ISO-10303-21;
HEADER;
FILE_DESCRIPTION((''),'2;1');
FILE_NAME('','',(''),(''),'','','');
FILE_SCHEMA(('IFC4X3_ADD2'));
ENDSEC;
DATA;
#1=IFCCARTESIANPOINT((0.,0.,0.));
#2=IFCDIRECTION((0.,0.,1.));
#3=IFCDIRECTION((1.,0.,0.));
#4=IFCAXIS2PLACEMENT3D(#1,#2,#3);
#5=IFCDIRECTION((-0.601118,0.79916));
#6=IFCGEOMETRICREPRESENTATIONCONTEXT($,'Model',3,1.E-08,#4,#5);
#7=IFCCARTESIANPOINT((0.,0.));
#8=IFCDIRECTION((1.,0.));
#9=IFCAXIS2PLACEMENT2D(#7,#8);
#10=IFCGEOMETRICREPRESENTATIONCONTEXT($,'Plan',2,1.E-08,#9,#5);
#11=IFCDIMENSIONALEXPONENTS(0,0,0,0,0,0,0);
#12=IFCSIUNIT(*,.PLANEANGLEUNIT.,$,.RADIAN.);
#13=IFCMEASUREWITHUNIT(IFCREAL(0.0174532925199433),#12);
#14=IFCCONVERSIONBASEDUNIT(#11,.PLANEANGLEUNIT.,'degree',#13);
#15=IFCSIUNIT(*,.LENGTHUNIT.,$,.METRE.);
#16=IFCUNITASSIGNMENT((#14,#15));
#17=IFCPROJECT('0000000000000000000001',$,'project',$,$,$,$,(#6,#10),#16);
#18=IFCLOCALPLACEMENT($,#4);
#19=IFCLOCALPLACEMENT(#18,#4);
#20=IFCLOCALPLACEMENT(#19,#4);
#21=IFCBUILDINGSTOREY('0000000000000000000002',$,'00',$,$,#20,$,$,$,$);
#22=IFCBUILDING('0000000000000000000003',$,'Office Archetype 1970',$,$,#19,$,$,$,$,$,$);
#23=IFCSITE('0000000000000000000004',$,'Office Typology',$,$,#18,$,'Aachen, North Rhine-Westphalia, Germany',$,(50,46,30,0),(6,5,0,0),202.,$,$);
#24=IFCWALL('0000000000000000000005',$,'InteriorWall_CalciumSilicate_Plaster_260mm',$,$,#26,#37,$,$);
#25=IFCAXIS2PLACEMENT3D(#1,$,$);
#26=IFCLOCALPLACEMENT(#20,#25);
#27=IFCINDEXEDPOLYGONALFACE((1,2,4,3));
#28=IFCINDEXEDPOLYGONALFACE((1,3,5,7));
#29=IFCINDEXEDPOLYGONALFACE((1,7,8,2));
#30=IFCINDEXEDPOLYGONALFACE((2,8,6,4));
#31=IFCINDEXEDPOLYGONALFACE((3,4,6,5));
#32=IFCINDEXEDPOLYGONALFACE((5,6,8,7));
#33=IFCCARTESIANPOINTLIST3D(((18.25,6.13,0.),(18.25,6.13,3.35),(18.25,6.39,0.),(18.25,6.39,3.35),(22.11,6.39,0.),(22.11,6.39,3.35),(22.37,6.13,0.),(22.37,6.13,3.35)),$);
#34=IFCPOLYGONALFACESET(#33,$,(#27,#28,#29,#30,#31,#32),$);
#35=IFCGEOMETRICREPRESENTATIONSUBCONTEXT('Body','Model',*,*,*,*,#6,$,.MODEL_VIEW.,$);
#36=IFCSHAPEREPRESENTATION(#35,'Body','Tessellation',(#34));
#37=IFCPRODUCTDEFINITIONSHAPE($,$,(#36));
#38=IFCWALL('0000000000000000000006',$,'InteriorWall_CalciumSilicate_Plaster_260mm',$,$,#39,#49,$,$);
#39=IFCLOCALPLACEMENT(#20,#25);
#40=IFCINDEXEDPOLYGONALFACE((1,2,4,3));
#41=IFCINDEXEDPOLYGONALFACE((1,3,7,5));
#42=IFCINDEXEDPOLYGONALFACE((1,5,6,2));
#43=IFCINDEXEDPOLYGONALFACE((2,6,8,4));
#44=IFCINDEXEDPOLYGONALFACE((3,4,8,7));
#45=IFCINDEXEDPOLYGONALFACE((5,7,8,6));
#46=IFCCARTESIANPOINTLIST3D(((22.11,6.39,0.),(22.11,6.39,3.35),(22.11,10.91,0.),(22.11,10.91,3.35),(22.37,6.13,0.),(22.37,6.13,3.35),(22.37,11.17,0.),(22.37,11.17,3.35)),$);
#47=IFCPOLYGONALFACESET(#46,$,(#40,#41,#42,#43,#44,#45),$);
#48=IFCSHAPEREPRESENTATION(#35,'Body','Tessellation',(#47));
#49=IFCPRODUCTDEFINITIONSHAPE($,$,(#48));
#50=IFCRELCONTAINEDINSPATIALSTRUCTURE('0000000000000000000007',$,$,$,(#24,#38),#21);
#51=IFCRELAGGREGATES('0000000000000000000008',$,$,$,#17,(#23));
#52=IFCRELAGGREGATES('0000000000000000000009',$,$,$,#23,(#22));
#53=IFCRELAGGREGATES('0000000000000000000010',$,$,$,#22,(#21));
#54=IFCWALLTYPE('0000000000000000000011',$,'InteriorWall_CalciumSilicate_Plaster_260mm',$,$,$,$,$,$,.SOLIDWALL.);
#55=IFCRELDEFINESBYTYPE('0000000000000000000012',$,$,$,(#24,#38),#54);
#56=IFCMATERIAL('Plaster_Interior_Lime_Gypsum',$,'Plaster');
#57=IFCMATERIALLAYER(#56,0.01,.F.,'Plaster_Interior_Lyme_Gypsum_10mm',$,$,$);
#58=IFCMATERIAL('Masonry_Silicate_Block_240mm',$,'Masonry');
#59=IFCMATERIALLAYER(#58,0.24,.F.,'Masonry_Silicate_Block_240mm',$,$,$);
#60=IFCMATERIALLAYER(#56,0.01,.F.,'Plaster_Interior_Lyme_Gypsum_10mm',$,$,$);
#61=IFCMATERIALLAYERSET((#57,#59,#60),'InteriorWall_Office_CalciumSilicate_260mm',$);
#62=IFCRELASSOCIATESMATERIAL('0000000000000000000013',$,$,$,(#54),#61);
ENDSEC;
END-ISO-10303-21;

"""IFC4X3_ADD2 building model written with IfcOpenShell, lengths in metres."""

from ifc_helpers import new_model, entity, si_unit, converted_unit, direction, frame, origin_with_axes, origin_2d_with_axis, place, context, subcontext, project, spatial, line, indexed_curve, outline, extrude, material, layer, layer_set, type_object, element, save


model = new_model("IFC4X3_ADD2")

# Units and contexts
model_context = context("Model", 3, precision=1e-08, world=origin_with_axes(), true_north=direction((-0.601118, 0.79916)))
plan_context = context("Plan", 2, precision=1e-08, world=origin_2d_with_axis(), true_north=direction((-0.601118, 0.79916)))
body_context = subcontext(model_context, "Body", "Model", "MODEL_VIEW")
ifc_project = project(units=[converted_unit("PLANEANGLEUNIT", "degree", entity("IfcReal", 0.0174532925199433), si_unit("PLANEANGLEUNIT", "RADIAN"), dimensions=[0, 0, 0, 0, 0, 0, 0]), si_unit("LENGTHUNIT", "METRE")], contexts=[model_context, plan_context])

# Site, building, storey
site_placement = place(None, origin_with_axes())
site = spatial("IfcSite", under=ifc_project, at=site_placement, Name="Office Typology", LongName="Aachen, North Rhine-Westphalia, Germany", RefLatitude=(50, 46, 30, 0), RefLongitude=(6, 5, 0, 0), RefElevation=202.0)
building_placement = place(site_placement, origin_with_axes())
building = spatial("IfcBuilding", under=site, at=building_placement, Name="Office Archetype 1970")
storey_placement = place(building_placement, origin_with_axes())
storey = spatial("IfcBuildingStorey", under=building, at=storey_placement, Name="00")

# Walls
ifc_material_1 = material(Name="Plaster_Interior_Lime_Gypsum", Category="Plaster")
ifc_layer_1 = layer(ifc_material_1, 0.01, ventilated=False, Name="Plaster_Interior_Lyme_Gypsum_10mm")
ifc_material_2 = material(Name="Masonry_Silicate_Block_240mm", Category="Masonry")
ifc_layer_2 = layer(ifc_material_2, 0.24, ventilated=False, Name="Masonry_Silicate_Block_240mm")
ifc_layer_3 = layer(ifc_material_1, 0.01, ventilated=False, Name="Plaster_Interior_Lyme_Gypsum_10mm")
ifc_layer_set_1 = layer_set([ifc_layer_1, ifc_layer_2, ifc_layer_3], Name="InteriorWall_Office_CalciumSilicate_260mm")
wall_type_1 = type_object("IfcWallType", Name="InteriorWall_CalciumSilicate_Plaster_260mm", PredefinedType="SOLIDWALL", material=ifc_layer_set_1)
wall_1_placement = place(storey_placement, frame((18.25, 6.13, 0.0), z_axis=(0.0, 0.0, 1.0), x_axis=(1.0, 0.0, 0.0)))
element("IfcWall", 1, at=wall_1_placement, inside=storey, type_object=wall_type_1, Name="InteriorWall_CalciumSilicate_Plaster_260mm", context=body_context, shape_type="SweptSolid", body=[
    extrude(outline(indexed_curve([(0.0, 0.0), (0.0, 0.26), (3.86, 0.26), (4.12, 0.0)], segments=[line(1, 2, 3, 4, 1)])), origin_with_axes(), (0.0, 0.0, 1.0), 3.35),
])
wall_2_placement = place(storey_placement, frame((22.37, 6.13, 0.0), z_axis=(0.0, 0.0, 1.0), x_axis=(0.0, 1.0, 0.0)))
element("IfcWall", 2, at=wall_2_placement, inside=storey, type_object=wall_type_1, Name="InteriorWall_CalciumSilicate_Plaster_260mm", context=body_context, shape_type="SweptSolid", body=[
    extrude(outline(indexed_curve([(0.0, 0.0), (0.26, 0.26), (4.78, 0.26), (5.04, 0.0)], segments=[line(1, 2, 3, 4, 1)])), origin_with_axes(), (0.0, 0.0, 1.0), 3.35),
])

save(model, "model.ifc")
